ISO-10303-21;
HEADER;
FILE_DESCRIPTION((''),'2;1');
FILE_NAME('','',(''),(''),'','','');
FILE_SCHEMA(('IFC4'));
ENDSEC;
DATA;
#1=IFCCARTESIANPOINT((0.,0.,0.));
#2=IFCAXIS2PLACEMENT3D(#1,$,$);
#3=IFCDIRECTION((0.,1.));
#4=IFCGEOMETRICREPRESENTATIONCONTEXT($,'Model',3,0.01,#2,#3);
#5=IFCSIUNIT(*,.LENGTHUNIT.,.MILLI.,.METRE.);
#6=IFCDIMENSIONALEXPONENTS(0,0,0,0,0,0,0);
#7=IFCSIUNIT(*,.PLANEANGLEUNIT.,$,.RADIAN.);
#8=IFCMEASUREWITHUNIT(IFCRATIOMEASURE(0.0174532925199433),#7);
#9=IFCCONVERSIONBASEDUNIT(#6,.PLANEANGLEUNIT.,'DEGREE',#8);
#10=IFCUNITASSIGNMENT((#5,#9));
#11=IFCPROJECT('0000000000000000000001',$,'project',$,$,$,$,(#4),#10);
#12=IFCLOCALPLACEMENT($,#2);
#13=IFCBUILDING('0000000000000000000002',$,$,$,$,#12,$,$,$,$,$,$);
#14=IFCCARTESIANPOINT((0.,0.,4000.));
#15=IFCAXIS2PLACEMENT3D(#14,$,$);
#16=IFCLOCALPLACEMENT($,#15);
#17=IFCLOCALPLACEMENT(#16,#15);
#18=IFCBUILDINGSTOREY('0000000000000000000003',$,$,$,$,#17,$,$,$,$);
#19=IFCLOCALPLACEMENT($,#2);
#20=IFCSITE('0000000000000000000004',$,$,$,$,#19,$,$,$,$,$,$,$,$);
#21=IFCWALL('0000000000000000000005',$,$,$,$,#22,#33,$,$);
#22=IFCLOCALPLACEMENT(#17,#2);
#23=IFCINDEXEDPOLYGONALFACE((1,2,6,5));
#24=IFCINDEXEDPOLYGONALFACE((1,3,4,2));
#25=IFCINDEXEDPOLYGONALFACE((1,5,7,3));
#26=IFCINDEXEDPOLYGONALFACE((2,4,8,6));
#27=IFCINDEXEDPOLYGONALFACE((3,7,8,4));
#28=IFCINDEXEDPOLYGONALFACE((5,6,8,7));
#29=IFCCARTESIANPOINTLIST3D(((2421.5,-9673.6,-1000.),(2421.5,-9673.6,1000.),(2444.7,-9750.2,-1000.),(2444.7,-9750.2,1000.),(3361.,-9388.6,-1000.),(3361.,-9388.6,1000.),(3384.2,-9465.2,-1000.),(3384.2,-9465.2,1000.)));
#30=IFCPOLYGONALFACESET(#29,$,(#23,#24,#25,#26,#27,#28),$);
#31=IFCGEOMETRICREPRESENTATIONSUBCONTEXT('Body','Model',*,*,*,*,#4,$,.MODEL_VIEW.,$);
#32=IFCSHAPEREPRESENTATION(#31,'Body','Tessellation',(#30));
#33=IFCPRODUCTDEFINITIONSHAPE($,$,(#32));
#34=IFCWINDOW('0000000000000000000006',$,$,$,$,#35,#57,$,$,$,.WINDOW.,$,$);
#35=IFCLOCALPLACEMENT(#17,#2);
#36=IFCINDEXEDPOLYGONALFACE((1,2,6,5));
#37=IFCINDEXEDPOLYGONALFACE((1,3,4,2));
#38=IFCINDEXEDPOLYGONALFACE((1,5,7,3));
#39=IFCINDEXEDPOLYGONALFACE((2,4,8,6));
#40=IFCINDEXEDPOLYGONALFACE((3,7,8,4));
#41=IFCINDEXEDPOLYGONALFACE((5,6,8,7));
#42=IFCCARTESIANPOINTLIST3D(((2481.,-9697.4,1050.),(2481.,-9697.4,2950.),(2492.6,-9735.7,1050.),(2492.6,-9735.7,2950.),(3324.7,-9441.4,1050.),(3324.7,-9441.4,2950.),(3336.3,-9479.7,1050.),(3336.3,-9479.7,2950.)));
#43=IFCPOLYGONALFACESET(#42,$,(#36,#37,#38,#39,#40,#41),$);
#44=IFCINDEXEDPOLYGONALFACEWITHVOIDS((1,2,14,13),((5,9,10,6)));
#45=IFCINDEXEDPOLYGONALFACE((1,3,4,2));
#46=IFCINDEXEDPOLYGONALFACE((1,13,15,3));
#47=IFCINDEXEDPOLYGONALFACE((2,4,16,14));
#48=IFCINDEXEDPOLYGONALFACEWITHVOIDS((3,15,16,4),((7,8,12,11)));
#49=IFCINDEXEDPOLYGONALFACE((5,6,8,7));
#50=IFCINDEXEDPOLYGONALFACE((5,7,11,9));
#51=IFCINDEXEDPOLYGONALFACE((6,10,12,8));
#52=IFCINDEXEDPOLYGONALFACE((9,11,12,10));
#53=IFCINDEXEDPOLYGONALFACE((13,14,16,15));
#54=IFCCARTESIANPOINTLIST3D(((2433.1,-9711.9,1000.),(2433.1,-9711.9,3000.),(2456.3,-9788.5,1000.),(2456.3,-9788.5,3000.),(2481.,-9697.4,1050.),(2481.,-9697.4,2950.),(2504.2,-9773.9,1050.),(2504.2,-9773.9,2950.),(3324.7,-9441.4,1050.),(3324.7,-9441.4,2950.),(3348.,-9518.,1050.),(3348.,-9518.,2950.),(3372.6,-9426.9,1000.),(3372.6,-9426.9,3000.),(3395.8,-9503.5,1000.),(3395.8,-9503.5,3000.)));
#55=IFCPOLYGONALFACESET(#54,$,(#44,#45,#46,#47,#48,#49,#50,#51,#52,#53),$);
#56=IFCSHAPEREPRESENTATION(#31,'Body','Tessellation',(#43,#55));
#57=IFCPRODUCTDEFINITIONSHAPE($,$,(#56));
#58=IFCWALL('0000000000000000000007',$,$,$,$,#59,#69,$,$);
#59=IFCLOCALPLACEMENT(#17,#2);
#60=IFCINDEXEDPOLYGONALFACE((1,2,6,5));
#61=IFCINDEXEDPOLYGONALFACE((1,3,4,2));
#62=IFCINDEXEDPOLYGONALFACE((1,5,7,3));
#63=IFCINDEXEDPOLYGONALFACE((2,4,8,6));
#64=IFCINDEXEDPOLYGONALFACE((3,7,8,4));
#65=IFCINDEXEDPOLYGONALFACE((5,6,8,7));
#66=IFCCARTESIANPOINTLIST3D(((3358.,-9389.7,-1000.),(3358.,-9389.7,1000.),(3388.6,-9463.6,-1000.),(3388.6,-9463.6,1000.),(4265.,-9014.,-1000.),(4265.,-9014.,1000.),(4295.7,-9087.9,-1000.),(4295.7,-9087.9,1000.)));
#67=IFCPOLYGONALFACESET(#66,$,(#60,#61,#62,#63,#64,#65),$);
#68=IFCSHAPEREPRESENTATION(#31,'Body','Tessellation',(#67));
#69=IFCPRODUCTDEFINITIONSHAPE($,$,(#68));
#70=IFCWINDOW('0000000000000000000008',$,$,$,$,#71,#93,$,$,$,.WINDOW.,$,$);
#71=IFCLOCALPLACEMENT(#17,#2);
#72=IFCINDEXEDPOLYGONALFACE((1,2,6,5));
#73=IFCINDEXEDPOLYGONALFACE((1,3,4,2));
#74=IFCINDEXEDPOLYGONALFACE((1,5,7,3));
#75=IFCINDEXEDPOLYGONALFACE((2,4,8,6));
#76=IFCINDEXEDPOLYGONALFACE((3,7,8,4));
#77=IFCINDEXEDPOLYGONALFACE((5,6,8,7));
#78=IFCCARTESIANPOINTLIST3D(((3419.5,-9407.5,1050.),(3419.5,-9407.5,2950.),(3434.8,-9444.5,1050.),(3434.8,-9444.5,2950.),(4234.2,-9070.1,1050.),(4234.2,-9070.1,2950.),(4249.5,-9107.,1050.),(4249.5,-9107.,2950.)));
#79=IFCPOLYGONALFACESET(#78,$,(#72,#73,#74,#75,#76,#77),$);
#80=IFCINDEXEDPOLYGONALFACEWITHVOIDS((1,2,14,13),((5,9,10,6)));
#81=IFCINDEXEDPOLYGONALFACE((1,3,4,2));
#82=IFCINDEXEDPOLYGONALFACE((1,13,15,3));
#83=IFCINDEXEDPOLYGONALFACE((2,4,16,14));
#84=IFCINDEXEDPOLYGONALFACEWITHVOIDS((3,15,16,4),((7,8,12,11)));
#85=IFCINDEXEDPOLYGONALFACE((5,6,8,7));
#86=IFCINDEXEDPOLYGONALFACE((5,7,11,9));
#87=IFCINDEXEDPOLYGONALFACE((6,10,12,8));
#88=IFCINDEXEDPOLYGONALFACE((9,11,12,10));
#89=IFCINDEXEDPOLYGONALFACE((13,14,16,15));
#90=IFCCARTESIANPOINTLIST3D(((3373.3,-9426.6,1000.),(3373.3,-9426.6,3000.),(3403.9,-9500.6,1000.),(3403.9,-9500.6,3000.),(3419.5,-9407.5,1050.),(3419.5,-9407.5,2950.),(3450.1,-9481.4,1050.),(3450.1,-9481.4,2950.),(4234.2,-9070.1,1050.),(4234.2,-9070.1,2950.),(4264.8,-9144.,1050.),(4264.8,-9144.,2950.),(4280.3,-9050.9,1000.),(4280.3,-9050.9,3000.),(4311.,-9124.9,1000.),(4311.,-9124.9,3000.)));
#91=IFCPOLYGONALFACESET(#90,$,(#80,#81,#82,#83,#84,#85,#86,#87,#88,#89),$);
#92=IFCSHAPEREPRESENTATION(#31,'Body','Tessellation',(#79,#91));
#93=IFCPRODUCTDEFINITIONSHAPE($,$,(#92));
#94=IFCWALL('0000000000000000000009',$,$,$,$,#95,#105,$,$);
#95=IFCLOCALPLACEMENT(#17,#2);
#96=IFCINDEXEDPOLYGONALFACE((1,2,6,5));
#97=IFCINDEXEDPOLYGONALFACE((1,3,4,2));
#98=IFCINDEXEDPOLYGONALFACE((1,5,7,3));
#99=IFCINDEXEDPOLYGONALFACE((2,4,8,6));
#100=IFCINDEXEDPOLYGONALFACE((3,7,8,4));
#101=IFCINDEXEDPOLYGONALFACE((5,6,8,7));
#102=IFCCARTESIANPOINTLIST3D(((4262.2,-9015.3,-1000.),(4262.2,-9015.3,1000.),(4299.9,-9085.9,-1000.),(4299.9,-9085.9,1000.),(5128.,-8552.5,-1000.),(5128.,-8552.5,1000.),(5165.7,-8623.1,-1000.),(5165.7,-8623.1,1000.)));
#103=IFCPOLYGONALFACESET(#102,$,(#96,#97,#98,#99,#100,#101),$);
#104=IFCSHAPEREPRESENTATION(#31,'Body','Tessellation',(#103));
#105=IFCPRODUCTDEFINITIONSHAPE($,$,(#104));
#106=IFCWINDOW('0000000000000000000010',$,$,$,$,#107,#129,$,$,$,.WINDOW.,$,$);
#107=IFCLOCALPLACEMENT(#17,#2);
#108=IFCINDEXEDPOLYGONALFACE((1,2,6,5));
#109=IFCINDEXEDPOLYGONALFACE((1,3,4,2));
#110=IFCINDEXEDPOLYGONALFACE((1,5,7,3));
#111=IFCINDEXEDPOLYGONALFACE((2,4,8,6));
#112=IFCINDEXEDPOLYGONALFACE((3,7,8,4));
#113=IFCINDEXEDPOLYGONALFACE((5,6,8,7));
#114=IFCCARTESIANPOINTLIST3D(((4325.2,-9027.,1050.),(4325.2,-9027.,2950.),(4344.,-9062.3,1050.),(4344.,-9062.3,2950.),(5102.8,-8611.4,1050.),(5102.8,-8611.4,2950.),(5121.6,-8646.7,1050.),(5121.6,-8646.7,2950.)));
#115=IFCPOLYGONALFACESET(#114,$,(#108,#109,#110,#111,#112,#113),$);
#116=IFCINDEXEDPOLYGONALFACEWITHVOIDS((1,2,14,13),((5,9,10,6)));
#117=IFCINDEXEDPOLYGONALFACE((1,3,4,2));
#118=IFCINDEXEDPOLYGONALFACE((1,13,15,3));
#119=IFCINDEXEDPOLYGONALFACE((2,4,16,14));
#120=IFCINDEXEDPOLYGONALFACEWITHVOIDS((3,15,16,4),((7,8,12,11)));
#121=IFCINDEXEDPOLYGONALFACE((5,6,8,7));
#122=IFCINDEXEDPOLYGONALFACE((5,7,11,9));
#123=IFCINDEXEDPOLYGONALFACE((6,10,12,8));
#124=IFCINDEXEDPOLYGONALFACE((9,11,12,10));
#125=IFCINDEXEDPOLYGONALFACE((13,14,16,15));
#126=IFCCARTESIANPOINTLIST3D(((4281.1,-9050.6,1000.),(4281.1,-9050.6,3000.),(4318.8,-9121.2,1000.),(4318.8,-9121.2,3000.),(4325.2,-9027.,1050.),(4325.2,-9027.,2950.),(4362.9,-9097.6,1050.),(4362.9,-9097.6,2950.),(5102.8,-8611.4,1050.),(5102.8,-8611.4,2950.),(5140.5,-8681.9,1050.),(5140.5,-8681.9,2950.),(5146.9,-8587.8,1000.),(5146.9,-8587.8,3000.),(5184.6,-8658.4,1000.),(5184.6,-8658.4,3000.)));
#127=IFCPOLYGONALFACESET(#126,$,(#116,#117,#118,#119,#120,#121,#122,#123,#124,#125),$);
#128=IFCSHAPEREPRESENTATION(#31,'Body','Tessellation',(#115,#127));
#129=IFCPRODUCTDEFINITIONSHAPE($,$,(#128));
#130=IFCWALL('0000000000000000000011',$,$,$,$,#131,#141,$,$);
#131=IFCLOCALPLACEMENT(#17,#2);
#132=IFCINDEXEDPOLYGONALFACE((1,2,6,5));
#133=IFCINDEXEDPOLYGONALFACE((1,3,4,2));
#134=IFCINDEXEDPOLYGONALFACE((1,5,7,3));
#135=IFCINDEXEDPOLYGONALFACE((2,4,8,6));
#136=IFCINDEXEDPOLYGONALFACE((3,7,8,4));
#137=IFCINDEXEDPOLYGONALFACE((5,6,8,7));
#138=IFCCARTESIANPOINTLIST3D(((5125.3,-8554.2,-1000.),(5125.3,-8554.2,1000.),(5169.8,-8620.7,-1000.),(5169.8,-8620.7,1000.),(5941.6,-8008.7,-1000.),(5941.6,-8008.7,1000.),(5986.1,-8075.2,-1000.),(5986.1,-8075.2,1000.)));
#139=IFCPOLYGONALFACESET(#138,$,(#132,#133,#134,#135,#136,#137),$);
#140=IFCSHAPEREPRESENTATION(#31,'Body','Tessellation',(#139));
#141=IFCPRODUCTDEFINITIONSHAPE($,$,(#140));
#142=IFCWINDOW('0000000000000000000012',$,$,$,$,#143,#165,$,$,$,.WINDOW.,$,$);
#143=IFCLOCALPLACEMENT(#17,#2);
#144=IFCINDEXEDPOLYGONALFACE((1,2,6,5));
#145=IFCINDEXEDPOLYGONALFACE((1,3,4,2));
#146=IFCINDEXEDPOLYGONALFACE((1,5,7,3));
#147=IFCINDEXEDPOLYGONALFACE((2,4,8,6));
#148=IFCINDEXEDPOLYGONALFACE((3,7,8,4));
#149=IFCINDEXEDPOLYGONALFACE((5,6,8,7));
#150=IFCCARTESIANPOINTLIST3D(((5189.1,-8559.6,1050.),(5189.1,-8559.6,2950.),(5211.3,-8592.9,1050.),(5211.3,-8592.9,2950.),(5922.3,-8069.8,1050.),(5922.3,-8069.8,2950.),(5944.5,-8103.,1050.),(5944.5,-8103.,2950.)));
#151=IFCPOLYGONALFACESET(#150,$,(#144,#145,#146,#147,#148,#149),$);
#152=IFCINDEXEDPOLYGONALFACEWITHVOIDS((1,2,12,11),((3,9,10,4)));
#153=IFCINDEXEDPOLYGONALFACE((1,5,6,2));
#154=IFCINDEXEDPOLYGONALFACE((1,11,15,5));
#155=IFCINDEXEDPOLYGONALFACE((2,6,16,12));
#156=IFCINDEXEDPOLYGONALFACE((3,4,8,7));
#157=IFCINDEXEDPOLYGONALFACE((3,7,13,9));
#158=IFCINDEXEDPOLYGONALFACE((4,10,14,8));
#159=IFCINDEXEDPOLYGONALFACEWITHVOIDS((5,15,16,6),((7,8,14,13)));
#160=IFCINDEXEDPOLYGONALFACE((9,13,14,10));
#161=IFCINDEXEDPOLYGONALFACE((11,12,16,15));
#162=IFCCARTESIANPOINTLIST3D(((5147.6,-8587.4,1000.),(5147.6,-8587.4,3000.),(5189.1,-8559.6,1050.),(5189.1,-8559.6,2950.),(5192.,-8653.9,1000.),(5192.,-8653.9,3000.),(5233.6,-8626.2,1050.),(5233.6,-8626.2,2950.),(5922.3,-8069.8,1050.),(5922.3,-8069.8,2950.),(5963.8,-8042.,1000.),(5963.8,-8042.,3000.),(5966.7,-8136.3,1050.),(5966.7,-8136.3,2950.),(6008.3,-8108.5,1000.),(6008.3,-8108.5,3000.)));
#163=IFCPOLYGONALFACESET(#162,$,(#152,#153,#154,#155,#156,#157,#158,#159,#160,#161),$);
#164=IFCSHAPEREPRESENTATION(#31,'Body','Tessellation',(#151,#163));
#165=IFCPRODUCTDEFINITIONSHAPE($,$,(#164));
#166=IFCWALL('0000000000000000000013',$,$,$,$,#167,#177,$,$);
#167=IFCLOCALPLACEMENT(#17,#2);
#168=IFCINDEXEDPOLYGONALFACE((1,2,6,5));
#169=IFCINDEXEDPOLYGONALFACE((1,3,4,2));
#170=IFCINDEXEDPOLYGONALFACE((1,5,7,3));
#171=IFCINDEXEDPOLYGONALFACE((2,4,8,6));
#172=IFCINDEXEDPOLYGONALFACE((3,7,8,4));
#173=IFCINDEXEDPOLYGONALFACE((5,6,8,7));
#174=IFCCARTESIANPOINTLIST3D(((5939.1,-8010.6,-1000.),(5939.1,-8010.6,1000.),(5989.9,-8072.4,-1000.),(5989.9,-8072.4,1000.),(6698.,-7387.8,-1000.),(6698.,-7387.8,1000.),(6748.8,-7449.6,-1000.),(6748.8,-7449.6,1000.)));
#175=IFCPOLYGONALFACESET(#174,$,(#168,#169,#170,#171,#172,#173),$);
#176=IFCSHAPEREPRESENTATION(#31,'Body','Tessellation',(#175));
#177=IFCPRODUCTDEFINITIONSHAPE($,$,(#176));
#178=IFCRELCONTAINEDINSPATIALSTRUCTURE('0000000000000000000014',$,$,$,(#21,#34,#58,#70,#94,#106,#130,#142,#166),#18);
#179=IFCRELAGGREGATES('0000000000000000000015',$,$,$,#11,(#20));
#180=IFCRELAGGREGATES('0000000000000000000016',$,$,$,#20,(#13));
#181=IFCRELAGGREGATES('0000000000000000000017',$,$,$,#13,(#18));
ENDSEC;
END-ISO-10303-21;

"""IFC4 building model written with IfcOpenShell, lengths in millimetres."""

from ifc_helpers import new_model, entity, si_unit, converted_unit, direction, frame, origin, origin_2d, place, context, subcontext, project, spatial, rectangle, extrude, element, save


model = new_model("IFC4")

# Units and contexts
model_context = context("Model", 3, precision=0.01, world=origin(), true_north=direction((0.0, 1.0)))
body_context = subcontext(model_context, "Body", "Model", "MODEL_VIEW")
ifc_project = project(units=[si_unit("LENGTHUNIT", "METRE", prefix="MILLI"), converted_unit("PLANEANGLEUNIT", "DEGREE", entity("IfcRatioMeasure", 0.0174532925199433), si_unit("PLANEANGLEUNIT", "RADIAN"), dimensions=[0, 0, 0, 0, 0, 0, 0])], contexts=[model_context])

# Site, building, storey
site_placement = place(None, origin())
site = spatial("IfcSite", under=ifc_project, at=site_placement)
building_placement = place(None, origin())
building = spatial("IfcBuilding", under=site, at=building_placement)
placement = place(None, frame((0.0, 0.0, 4000.0)))
storey_placement = place(placement, frame((0.0, 0.0, 4000.0)))
storey = spatial("IfcBuildingStorey", under=building, at=storey_placement)

# Shared definitions
cartesian_point_1 = entity("IfcCartesianPoint", [-440.9, -950.0])
shared_polyline = entity("IfcPolyline", [cartesian_point_1, entity("IfcCartesianPoint", [-440.9, 950.0]), entity("IfcCartesianPoint", [-440.9, 950.0]), entity("IfcCartesianPoint", [440.9, 950.0]), entity("IfcCartesianPoint", [440.9, 950.0]), entity("IfcCartesianPoint", [440.9, -950.0]), entity("IfcCartesianPoint", [440.9, -950.0]), entity("IfcCartesianPoint", [-440.9, -950.0]), cartesian_point_1])

# Wall
wall_1_placement = place(storey_placement, frame((2902.8, -9569.4, -1000.0), z_axis=(0.0, 0.0, 1.0), x_axis=(9569.403667, 2902.845753, 0.0)))
element("IfcWall", 1, at=wall_1_placement, inside=storey, context=body_context, shape_type="SweptSolid", body=[
    extrude(rectangle(XDim=981.7, YDim=80.0, at=origin_2d()), origin(), (0.0, 0.0, 1.0), 2000.0),
])

# Window
window_1_placement = place(storey_placement, frame((2902.8, -9569.4, 2000.0), z_axis=(0.0, 0.0, 1.0), x_axis=(9569.403667, 2902.845753, 0.0)))
cartesian_point_2 = entity("IfcCartesianPoint", [-490.9, -1000.0])
element("IfcWindow", 2, at=window_1_placement, inside=storey, PredefinedType="WINDOW", context=body_context, shape_type="SweptSolid", body=[
    entity("IfcExtrudedAreaSolid", entity("IfcArbitraryClosedProfileDef", "AREA", None, shared_polyline), entity("IfcAxis2Placement3D", entity("IfcCartesianPoint", [0.0, 0.0, 0.0]), entity("IfcDirection", [0.0, -1.0, 0.0]), entity("IfcDirection", [1.0, 0.0, 0.0])), entity("IfcDirection", [0.0, 0.0, 1.0]), 40.0),
    entity("IfcExtrudedAreaSolid", entity("IfcArbitraryProfileDefWithVoids", "AREA", None, entity("IfcPolyline", [cartesian_point_2, entity("IfcCartesianPoint", [-490.9, 1000.0]), entity("IfcCartesianPoint", [-490.9, 1000.0]), entity("IfcCartesianPoint", [490.9, 1000.0]), entity("IfcCartesianPoint", [490.9, 1000.0]), entity("IfcCartesianPoint", [490.9, -1000.0]), entity("IfcCartesianPoint", [490.9, -1000.0]), entity("IfcCartesianPoint", [-490.9, -1000.0]), cartesian_point_2]), [shared_polyline]), entity("IfcAxis2Placement3D", entity("IfcCartesianPoint", [0.0, 0.0, 0.0]), entity("IfcDirection", [0.0, -1.0, 0.0]), entity("IfcDirection", [1.0, 0.0, 0.0])), entity("IfcDirection", [0.0, 0.0, 1.0]), 80.0),
])

# Wall
wall_2_placement = place(storey_placement, frame((3826.8, -9238.8, -1000.0), z_axis=(0.0, 0.0, 1.0), x_axis=(9238.794667, 3826.835911, 0.0)))
element("IfcWall", 3, at=wall_2_placement, inside=storey, context=body_context, shape_type="SweptSolid", body=[
    extrude(rectangle(XDim=981.7, YDim=80.0, at=origin_2d()), origin(), (0.0, 0.0, 1.0), 2000.0),
])

# Window
window_2_placement = place(storey_placement, frame((3826.8, -9238.8, 2000.0), z_axis=(0.0, 0.0, 1.0), x_axis=(9238.794667, 3826.835911, 0.0)))
cartesian_point_3 = entity("IfcCartesianPoint", [-490.9, -1000.0])
element("IfcWindow", 4, at=window_2_placement, inside=storey, PredefinedType="WINDOW", context=body_context, shape_type="SweptSolid", body=[
    entity("IfcExtrudedAreaSolid", entity("IfcArbitraryClosedProfileDef", "AREA", None, shared_polyline), entity("IfcAxis2Placement3D", entity("IfcCartesianPoint", [0.0, 0.0, 0.0]), entity("IfcDirection", [0.0, -1.0, 0.0]), entity("IfcDirection", [1.0, 0.0, 0.0])), entity("IfcDirection", [0.0, 0.0, 1.0]), 40.0),
    entity("IfcExtrudedAreaSolid", entity("IfcArbitraryProfileDefWithVoids", "AREA", None, entity("IfcPolyline", [cartesian_point_3, entity("IfcCartesianPoint", [-490.9, 1000.0]), entity("IfcCartesianPoint", [-490.9, 1000.0]), entity("IfcCartesianPoint", [490.9, 1000.0]), entity("IfcCartesianPoint", [490.9, 1000.0]), entity("IfcCartesianPoint", [490.9, -1000.0]), entity("IfcCartesianPoint", [490.9, -1000.0]), entity("IfcCartesianPoint", [-490.9, -1000.0]), cartesian_point_3]), [shared_polyline]), entity("IfcAxis2Placement3D", entity("IfcCartesianPoint", [0.0, 0.0, 0.0]), entity("IfcDirection", [0.0, -1.0, 0.0]), entity("IfcDirection", [1.0, 0.0, 0.0])), entity("IfcDirection", [0.0, 0.0, 1.0]), 80.0),
])

# Wall
wall_3_placement = place(storey_placement, frame((4714.0, -8819.2, -1000.0), z_axis=(0.0, 0.0, 1.0), x_axis=(8819.212769, 4713.967134, 0.0)))
element("IfcWall", 5, at=wall_3_placement, inside=storey, context=body_context, shape_type="SweptSolid", body=[
    extrude(rectangle(XDim=981.7, YDim=80.0, at=origin_2d()), origin(), (0.0, 0.0, 1.0), 2000.0),
])

# Window
window_3_placement = place(storey_placement, frame((4714.0, -8819.2, 2000.0), z_axis=(0.0, 0.0, 1.0), x_axis=(8819.212769, 4713.967134, 0.0)))
cartesian_point_4 = entity("IfcCartesianPoint", [-490.9, -1000.0])
element("IfcWindow", 6, at=window_3_placement, inside=storey, PredefinedType="WINDOW", context=body_context, shape_type="SweptSolid", body=[
    entity("IfcExtrudedAreaSolid", entity("IfcArbitraryClosedProfileDef", "AREA", None, shared_polyline), entity("IfcAxis2Placement3D", entity("IfcCartesianPoint", [0.0, 0.0, 0.0]), entity("IfcDirection", [0.0, -1.0, 0.0]), entity("IfcDirection", [1.0, 0.0, 0.0])), entity("IfcDirection", [0.0, 0.0, 1.0]), 40.0),
    entity("IfcExtrudedAreaSolid", entity("IfcArbitraryProfileDefWithVoids", "AREA", None, entity("IfcPolyline", [cartesian_point_4, entity("IfcCartesianPoint", [-490.9, 1000.0]), entity("IfcCartesianPoint", [-490.9, 1000.0]), entity("IfcCartesianPoint", [490.9, 1000.0]), entity("IfcCartesianPoint", [490.9, 1000.0]), entity("IfcCartesianPoint", [490.9, -1000.0]), entity("IfcCartesianPoint", [490.9, -1000.0]), entity("IfcCartesianPoint", [-490.9, -1000.0]), cartesian_point_4]), [shared_polyline]), entity("IfcAxis2Placement3D", entity("IfcCartesianPoint", [0.0, 0.0, 0.0]), entity("IfcDirection", [0.0, -1.0, 0.0]), entity("IfcDirection", [1.0, 0.0, 0.0])), entity("IfcDirection", [0.0, 0.0, 1.0]), 80.0),
])

# Wall
wall_4_placement = place(storey_placement, frame((5555.7, -8314.7, -1000.0), z_axis=(0.0, 0.0, 1.0), x_axis=(8314.697373, 5555.700459, 0.0)))
element("IfcWall", 7, at=wall_4_placement, inside=storey, context=body_context, shape_type="SweptSolid", body=[
    extrude(rectangle(XDim=981.7, YDim=80.0, at=origin_2d()), origin(), (0.0, 0.0, 1.0), 2000.0),
])

# Window
window_4_placement = place(storey_placement, frame((5555.7, -8314.7, 2000.0), z_axis=(0.0, 0.0, 1.0), x_axis=(8314.697373, 5555.700459, 0.0)))
cartesian_point_5 = entity("IfcCartesianPoint", [-490.9, -1000.0])
element("IfcWindow", 8, at=window_4_placement, inside=storey, PredefinedType="WINDOW", context=body_context, shape_type="SweptSolid", body=[
    entity("IfcExtrudedAreaSolid", entity("IfcArbitraryClosedProfileDef", "AREA", None, shared_polyline), entity("IfcAxis2Placement3D", entity("IfcCartesianPoint", [0.0, 0.0, 0.0]), entity("IfcDirection", [0.0, -1.0, 0.0]), entity("IfcDirection", [1.0, 0.0, 0.0])), entity("IfcDirection", [0.0, 0.0, 1.0]), 40.0),
    entity("IfcExtrudedAreaSolid", entity("IfcArbitraryProfileDefWithVoids", "AREA", None, entity("IfcPolyline", [cartesian_point_5, entity("IfcCartesianPoint", [-490.9, 1000.0]), entity("IfcCartesianPoint", [-490.9, 1000.0]), entity("IfcCartesianPoint", [490.9, 1000.0]), entity("IfcCartesianPoint", [490.9, 1000.0]), entity("IfcCartesianPoint", [490.9, -1000.0]), entity("IfcCartesianPoint", [490.9, -1000.0]), entity("IfcCartesianPoint", [-490.9, -1000.0]), cartesian_point_5]), [shared_polyline]), entity("IfcAxis2Placement3D", entity("IfcCartesianPoint", [0.0, 0.0, 0.0]), entity("IfcDirection", [0.0, -1.0, 0.0]), entity("IfcDirection", [1.0, 0.0, 0.0])), entity("IfcDirection", [0.0, 0.0, 1.0]), 80.0),
])

# Wall
wall_5_placement = place(storey_placement, frame((6343.9, -7730.1, -1000.0), z_axis=(0.0, 0.0, 1.0), x_axis=(7730.104195, 6343.933254, 0.0)))
element("IfcWall", 9, at=wall_5_placement, inside=storey, context=body_context, shape_type="SweptSolid", body=[
    extrude(rectangle(XDim=981.7, YDim=80.0, at=origin_2d()), origin(), (0.0, 0.0, 1.0), 2000.0),
])

save(model, "model.ifc")
